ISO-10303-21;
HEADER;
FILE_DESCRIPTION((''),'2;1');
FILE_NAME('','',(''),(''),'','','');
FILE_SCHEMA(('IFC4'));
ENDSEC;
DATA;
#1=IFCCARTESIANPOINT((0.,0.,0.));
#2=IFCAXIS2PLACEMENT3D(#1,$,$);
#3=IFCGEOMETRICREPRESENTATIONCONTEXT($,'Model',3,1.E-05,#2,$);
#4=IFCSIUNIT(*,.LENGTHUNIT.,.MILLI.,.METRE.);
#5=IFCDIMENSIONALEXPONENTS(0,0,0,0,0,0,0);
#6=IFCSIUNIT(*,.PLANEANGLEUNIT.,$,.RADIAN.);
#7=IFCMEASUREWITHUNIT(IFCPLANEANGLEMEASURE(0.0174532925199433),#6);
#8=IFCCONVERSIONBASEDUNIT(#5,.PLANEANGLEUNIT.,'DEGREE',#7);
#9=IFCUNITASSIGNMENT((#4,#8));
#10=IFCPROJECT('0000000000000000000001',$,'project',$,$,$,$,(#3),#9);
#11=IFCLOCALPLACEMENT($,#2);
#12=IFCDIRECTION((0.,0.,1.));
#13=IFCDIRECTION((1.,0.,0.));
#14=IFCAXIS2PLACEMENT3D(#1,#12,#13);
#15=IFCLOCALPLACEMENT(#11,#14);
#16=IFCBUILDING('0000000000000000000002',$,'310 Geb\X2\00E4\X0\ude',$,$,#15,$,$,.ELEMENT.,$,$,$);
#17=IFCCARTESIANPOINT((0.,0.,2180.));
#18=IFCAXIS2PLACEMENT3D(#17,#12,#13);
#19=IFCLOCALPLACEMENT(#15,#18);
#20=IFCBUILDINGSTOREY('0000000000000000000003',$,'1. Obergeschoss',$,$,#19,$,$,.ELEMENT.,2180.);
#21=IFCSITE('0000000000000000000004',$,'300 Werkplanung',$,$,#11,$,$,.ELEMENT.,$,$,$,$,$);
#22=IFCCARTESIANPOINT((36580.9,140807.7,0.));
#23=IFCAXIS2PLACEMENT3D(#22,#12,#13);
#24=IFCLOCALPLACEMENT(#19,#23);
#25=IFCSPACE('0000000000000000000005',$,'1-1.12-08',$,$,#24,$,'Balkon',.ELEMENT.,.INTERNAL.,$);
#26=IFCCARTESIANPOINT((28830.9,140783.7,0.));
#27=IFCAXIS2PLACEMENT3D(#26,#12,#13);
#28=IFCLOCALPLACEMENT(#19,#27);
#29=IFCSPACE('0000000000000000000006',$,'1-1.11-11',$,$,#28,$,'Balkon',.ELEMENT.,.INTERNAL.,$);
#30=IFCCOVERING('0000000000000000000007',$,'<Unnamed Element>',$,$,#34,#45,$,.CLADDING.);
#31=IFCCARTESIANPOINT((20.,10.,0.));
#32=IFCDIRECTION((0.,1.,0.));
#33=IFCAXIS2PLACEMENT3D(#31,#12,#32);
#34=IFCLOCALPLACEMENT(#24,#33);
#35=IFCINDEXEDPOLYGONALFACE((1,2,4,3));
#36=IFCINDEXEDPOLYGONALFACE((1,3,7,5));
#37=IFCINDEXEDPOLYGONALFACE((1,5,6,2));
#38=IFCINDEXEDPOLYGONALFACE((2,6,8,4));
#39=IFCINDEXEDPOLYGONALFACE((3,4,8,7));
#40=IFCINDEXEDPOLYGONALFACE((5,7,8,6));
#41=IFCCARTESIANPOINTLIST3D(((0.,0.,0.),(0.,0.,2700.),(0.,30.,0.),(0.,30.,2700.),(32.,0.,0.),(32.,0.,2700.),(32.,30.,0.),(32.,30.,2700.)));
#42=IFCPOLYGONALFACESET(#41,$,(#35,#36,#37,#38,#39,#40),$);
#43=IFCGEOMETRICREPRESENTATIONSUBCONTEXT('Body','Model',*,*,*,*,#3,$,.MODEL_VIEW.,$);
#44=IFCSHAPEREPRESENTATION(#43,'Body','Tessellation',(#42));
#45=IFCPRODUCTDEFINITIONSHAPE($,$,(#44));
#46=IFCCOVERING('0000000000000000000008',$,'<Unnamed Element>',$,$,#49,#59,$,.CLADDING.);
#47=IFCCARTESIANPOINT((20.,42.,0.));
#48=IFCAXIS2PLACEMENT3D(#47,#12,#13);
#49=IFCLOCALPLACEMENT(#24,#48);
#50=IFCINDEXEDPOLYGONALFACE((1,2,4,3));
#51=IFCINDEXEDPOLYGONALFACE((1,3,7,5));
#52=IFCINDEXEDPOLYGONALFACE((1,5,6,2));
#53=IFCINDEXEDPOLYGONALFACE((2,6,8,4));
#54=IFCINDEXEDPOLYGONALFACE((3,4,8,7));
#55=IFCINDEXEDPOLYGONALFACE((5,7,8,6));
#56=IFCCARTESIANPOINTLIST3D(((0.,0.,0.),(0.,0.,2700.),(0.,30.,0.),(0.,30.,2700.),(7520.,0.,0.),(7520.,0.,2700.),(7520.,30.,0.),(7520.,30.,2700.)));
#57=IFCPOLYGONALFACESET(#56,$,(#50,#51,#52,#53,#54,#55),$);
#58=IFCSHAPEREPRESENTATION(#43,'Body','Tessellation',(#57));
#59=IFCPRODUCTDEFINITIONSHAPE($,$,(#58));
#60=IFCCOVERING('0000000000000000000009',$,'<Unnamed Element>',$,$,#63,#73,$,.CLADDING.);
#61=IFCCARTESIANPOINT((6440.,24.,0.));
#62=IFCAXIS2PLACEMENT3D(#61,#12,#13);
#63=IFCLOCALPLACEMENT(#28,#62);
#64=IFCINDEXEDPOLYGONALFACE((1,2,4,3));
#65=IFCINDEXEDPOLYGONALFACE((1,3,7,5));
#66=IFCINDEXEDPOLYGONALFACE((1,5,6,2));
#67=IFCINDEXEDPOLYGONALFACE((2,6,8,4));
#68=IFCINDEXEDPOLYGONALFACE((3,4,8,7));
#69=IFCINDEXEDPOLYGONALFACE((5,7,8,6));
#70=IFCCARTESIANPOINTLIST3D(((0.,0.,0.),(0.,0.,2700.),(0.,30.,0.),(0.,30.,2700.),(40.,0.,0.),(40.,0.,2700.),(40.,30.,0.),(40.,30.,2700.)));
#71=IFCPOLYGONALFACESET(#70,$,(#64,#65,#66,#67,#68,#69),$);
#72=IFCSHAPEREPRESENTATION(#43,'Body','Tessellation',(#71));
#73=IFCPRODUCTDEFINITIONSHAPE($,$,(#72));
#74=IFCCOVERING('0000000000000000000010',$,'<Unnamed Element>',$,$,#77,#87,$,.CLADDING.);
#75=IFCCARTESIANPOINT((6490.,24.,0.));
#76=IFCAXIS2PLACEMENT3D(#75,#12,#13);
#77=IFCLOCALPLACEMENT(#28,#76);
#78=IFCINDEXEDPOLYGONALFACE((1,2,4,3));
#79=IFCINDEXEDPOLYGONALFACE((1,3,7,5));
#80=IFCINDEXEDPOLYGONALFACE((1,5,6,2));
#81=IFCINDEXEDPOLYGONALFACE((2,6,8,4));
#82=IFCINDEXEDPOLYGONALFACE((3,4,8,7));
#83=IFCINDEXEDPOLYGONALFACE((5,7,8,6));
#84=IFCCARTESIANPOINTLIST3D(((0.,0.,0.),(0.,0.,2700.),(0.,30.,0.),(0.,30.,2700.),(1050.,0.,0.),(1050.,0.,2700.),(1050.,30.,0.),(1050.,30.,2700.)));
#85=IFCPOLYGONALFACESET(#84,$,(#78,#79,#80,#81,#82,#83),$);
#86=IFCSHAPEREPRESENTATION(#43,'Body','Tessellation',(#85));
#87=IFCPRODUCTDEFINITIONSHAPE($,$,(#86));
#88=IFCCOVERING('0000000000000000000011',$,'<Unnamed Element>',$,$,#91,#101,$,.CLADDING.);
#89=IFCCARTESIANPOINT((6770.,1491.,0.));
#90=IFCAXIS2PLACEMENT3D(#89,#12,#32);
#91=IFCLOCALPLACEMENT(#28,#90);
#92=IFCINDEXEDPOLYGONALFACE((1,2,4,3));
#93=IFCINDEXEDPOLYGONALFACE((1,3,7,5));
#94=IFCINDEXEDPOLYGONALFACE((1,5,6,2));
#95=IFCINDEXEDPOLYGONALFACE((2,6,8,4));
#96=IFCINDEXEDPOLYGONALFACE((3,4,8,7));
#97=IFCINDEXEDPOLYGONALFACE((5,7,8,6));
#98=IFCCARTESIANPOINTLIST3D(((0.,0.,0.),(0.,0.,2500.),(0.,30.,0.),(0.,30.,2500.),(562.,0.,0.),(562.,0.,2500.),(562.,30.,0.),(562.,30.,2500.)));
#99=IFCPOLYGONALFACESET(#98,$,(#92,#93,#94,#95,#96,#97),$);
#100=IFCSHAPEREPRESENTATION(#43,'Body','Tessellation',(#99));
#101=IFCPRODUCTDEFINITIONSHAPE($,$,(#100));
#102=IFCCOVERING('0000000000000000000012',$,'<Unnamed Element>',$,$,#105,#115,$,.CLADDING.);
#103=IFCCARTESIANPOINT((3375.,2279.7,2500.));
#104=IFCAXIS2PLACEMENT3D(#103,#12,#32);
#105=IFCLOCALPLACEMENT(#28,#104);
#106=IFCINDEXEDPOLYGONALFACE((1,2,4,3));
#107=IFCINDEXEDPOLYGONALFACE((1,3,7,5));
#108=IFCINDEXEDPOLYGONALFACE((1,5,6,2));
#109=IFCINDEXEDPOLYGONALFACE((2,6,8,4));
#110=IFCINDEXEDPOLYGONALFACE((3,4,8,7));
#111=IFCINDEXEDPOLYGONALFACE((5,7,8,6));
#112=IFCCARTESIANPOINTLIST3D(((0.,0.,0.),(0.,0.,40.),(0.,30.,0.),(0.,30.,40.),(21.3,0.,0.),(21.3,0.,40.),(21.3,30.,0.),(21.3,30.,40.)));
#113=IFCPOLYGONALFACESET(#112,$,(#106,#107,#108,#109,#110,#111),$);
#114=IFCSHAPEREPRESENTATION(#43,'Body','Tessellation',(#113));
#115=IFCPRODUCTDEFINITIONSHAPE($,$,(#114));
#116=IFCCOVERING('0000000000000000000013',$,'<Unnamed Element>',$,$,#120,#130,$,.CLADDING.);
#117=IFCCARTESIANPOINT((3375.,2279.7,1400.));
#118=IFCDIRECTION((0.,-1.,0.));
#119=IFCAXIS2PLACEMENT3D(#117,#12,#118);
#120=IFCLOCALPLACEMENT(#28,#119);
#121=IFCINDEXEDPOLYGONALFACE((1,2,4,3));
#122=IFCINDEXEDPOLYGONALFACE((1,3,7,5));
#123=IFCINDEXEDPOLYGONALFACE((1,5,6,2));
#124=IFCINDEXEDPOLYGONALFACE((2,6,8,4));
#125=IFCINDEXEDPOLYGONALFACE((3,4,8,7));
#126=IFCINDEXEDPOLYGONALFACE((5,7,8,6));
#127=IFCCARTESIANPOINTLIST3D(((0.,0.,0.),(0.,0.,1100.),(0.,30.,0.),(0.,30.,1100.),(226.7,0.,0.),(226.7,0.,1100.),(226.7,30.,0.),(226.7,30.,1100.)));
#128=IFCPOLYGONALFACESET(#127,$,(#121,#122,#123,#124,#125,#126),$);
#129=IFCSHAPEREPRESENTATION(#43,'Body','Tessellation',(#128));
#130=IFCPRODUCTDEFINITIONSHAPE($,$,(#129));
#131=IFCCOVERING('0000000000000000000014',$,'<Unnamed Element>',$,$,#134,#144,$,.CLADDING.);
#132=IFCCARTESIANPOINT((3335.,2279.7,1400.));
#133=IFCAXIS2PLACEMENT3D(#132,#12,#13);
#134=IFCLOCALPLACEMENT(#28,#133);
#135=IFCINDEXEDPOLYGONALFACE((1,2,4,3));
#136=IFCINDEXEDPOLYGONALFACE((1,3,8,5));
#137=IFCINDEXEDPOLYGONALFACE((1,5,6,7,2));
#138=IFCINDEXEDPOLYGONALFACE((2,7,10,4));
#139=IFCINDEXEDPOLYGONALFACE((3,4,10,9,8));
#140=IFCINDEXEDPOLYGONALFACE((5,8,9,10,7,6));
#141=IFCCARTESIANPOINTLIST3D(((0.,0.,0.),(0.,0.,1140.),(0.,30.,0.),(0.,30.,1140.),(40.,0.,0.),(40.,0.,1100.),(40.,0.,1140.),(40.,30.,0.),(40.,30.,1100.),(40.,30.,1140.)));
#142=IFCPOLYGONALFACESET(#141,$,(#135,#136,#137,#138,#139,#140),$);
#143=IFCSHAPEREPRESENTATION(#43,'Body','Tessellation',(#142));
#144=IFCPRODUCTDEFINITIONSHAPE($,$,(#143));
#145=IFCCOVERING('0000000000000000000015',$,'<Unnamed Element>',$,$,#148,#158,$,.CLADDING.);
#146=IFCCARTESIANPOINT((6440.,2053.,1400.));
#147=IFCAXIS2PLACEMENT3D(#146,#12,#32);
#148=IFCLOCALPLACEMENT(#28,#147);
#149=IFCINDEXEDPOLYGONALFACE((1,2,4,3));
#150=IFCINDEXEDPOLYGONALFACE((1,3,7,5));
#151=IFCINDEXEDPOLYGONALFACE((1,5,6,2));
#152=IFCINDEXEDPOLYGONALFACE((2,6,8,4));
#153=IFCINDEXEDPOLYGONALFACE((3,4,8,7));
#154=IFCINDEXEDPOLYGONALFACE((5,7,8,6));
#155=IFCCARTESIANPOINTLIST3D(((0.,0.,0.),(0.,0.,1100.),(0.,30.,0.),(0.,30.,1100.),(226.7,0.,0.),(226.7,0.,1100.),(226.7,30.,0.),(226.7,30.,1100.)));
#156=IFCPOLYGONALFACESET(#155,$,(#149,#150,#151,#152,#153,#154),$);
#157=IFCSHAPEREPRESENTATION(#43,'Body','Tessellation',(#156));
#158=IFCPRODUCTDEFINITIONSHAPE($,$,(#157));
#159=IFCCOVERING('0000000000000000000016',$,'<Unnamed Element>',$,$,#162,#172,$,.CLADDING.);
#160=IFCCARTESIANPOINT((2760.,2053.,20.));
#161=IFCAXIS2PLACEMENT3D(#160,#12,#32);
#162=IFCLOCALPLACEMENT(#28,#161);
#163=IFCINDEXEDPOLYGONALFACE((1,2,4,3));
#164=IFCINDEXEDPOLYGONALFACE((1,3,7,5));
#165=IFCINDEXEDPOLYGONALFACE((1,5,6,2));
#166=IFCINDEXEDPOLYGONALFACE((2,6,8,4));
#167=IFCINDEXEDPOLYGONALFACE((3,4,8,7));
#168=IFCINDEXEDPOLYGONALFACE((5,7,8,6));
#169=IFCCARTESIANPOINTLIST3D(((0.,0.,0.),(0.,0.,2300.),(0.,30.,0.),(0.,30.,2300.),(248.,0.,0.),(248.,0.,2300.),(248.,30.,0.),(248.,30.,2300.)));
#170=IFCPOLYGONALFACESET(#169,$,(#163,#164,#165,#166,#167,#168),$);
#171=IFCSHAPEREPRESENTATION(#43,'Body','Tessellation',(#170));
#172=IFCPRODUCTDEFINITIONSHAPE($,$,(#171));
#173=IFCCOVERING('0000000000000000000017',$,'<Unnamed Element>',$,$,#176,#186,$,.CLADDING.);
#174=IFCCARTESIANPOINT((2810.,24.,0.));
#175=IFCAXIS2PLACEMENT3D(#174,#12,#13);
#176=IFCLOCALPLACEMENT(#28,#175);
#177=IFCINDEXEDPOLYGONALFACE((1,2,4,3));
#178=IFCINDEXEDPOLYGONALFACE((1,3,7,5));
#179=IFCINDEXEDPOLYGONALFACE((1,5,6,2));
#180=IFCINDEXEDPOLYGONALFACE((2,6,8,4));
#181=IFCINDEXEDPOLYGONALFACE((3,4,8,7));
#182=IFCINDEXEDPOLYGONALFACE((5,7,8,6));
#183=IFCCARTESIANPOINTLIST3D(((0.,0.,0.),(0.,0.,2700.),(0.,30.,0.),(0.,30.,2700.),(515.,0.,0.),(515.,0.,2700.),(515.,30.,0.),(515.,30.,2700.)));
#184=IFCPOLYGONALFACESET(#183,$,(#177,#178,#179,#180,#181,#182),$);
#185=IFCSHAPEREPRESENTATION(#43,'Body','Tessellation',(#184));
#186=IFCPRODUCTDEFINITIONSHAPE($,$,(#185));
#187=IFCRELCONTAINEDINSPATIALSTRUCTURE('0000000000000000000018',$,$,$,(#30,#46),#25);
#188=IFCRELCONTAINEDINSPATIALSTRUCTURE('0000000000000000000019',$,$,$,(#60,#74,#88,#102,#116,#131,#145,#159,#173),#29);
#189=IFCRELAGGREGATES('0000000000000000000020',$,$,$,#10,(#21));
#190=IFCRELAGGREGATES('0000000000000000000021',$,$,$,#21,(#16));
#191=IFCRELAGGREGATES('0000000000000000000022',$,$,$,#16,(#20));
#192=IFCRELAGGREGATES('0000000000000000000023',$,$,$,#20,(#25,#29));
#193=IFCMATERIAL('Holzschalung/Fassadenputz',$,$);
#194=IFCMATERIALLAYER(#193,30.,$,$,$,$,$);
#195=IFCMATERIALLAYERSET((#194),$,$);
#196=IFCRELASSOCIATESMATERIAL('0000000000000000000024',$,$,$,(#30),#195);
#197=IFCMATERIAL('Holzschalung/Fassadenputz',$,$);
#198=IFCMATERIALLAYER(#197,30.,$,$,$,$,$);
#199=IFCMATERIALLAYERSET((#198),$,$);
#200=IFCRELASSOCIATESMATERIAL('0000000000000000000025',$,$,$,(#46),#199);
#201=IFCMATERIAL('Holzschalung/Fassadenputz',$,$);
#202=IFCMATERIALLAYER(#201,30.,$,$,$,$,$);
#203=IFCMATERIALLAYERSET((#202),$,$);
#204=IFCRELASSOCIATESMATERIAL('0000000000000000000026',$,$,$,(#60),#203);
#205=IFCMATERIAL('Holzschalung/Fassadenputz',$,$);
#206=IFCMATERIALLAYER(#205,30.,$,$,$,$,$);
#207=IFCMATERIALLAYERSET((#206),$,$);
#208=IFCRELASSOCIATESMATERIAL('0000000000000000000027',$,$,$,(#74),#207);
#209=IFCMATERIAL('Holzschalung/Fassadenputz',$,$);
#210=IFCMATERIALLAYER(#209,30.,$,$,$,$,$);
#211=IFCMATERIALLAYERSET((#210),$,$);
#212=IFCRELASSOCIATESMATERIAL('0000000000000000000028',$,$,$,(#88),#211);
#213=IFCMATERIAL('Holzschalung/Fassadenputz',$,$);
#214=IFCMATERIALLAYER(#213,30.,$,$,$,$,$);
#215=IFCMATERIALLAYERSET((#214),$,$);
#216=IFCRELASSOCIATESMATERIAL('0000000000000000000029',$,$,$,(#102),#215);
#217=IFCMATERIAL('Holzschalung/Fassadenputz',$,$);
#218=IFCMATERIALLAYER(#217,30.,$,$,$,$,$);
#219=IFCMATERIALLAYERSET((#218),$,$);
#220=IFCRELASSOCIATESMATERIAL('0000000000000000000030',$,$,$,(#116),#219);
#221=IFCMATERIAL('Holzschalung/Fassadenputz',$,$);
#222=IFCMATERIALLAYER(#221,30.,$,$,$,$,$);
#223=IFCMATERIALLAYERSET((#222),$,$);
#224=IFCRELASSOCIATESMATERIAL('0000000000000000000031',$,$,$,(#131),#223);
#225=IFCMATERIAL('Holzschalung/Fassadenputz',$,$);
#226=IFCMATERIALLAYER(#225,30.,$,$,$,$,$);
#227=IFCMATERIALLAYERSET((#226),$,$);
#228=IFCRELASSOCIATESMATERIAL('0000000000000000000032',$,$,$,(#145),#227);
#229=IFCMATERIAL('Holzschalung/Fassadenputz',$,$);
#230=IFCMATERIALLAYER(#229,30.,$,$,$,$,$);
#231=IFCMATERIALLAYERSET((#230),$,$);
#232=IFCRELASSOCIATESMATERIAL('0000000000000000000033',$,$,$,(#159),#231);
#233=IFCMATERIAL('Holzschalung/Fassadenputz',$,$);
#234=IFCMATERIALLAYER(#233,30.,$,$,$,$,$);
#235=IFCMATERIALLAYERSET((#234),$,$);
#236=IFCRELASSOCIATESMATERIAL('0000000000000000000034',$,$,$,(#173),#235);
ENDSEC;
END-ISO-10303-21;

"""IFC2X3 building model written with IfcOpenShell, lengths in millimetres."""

from ifc_helpers import new_model, entity, si_unit, converted_unit, frame, frame_2d, origin, origin_with_axes, place, context, subcontext, project, spatial, polyline, rectangle, outline, extrude, material, layer, layer_set, layer_usage, element, save


model = new_model("IFC2X3")

# Units and contexts
model_context = context("Model", 3, precision=1e-05, world=origin())
body_context = subcontext(model_context, "Body", "Model", "MODEL_VIEW")
ifc_project = project(units=[si_unit("LENGTHUNIT", "METRE", prefix="MILLI"), converted_unit("PLANEANGLEUNIT", "DEGREE", entity("IfcPlaneAngleMeasure", 0.0174532925199433), si_unit("PLANEANGLEUNIT", "RADIAN"), dimensions=[0, 0, 0, 0, 0, 0, 0])], contexts=[model_context])

# Site, building, storey
site_placement = place(None, origin())
site = spatial("IfcSite", under=ifc_project, at=site_placement, Name="300 Werkplanung", CompositionType="ELEMENT")
building_placement = place(site_placement, origin_with_axes())
building = spatial("IfcBuilding", under=site, at=building_placement, Name="310 Gebäude", CompositionType="ELEMENT")
storey_placement = place(building_placement, frame((0.0, 0.0, 2180.0), z_axis=(0.0, 0.0, 1.0), x_axis=(1.0, 0.0, 0.0)))
storey = spatial("IfcBuildingStorey", under=building, at=storey_placement, Name="1. Obergeschoss", CompositionType="ELEMENT", Elevation=2180.0)

# Shared definitions
space_1_placement = place(storey_placement, frame((36580.9, 140807.7, 0.0), z_axis=(0.0, 0.0, 1.0), x_axis=(1.0, 0.0, 0.0)))
space_1 = spatial("IfcSpace", under=storey, at=space_1_placement, Name="1-1.12-08", LongName="Balkon", CompositionType="ELEMENT", InteriorOrExteriorSpace="INTERNAL")

# Coverings
ifc_material_1 = material(Name="Holzschalung/Fassadenputz")
ifc_layer_1 = layer(ifc_material_1, 30.0)
ifc_layer_set_1 = layer_set([ifc_layer_1])
ifc_layer_usage_1 = layer_usage(ifc_layer_set_1, "AXIS3", "POSITIVE", 0.0)
covering_1_placement = place(space_1_placement, frame((20.0, 10.0, 0.0), z_axis=(0.0, 0.0, 1.0), x_axis=(0.0, 1.0, 0.0)))
element("IfcCovering", 1, at=covering_1_placement, inside=space_1, material=ifc_layer_usage_1, Name="<Unnamed Element>", PredefinedType="CLADDING", context=body_context, shape_type="SweptSolid", body=[
    extrude(rectangle(XDim=2700.0, YDim=32.0, at=frame_2d((-16.0, 1350.0), x_axis=(0.0, 1.0))), frame((32.0, 0.0, 2700.0), z_axis=(0.0, 1.0, 0.0), x_axis=(1.0, 0.0, 0.0)), (0.0, 0.0, 1.0), 30.0),
])
ifc_material_2 = material(Name="Holzschalung/Fassadenputz")
ifc_layer_2 = layer(ifc_material_2, 30.0)
ifc_layer_set_2 = layer_set([ifc_layer_2])
ifc_layer_usage_2 = layer_usage(ifc_layer_set_2, "AXIS3", "POSITIVE", 0.0)
covering_2_placement = place(space_1_placement, frame((20.0, 42.0, 0.0), z_axis=(0.0, 0.0, 1.0), x_axis=(1.0, 0.0, 0.0)))
element("IfcCovering", 2, at=covering_2_placement, inside=space_1, material=ifc_layer_usage_2, Name="<Unnamed Element>", PredefinedType="CLADDING", context=body_context, shape_type="SweptSolid", body=[
    extrude(rectangle(XDim=7520.0, YDim=2700.0, at=frame_2d((-3760.0, -1350.0), x_axis=(-1.0, 0.0))), frame((7520.0, 0.0, 0.0), z_axis=(0.0, 1.0, 0.0), x_axis=(1.0, 0.0, 0.0)), (0.0, 0.0, 1.0), 30.0),
])

# Shared definitions
space_2_placement = place(storey_placement, frame((28830.9, 140783.7, 0.0), z_axis=(0.0, 0.0, 1.0), x_axis=(1.0, 0.0, 0.0)))
space_2 = spatial("IfcSpace", under=storey, at=space_2_placement, Name="1-1.11-11", LongName="Balkon", CompositionType="ELEMENT", InteriorOrExteriorSpace="INTERNAL")

# Coverings
ifc_material_3 = material(Name="Holzschalung/Fassadenputz")
ifc_layer_3 = layer(ifc_material_3, 30.0)
ifc_layer_set_3 = layer_set([ifc_layer_3])
ifc_layer_usage_3 = layer_usage(ifc_layer_set_3, "AXIS3", "POSITIVE", 0.0)
covering_3_placement = place(space_2_placement, frame((6440.0, 24.0, 0.0), z_axis=(0.0, 0.0, 1.0), x_axis=(1.0, 0.0, 0.0)))
element("IfcCovering", 3, at=covering_3_placement, inside=space_2, material=ifc_layer_usage_3, Name="<Unnamed Element>", PredefinedType="CLADDING", context=body_context, shape_type="SweptSolid", body=[
    extrude(rectangle(XDim=2700.0, YDim=40.0, at=frame_2d((-20.0, 1350.0), x_axis=(0.0, 1.0))), frame((40.0, 0.0, 2700.0), z_axis=(0.0, 1.0, 0.0), x_axis=(1.0, 0.0, 0.0)), (0.0, 0.0, 1.0), 30.0),
])
ifc_material_4 = material(Name="Holzschalung/Fassadenputz")
ifc_layer_4 = layer(ifc_material_4, 30.0)
ifc_layer_set_4 = layer_set([ifc_layer_4])
ifc_layer_usage_4 = layer_usage(ifc_layer_set_4, "AXIS3", "POSITIVE", 0.0)
covering_4_placement = place(space_2_placement, frame((6490.0, 24.0, 0.0), z_axis=(0.0, 0.0, 1.0), x_axis=(1.0, 0.0, 0.0)))
element("IfcCovering", 4, at=covering_4_placement, inside=space_2, material=ifc_layer_usage_4, Name="<Unnamed Element>", PredefinedType="CLADDING", context=body_context, shape_type="SweptSolid", body=[
    extrude(rectangle(XDim=2700.0, YDim=1050.0, at=frame_2d((-525.0, 1350.0), x_axis=(0.0, 1.0))), frame((1050.0, 0.0, 2700.0), z_axis=(0.0, 1.0, 0.0), x_axis=(1.0, 0.0, 0.0)), (0.0, 0.0, 1.0), 30.0),
])
ifc_material_5 = material(Name="Holzschalung/Fassadenputz")
ifc_layer_5 = layer(ifc_material_5, 30.0)
ifc_layer_set_5 = layer_set([ifc_layer_5])
ifc_layer_usage_5 = layer_usage(ifc_layer_set_5, "AXIS3", "POSITIVE", 0.0)
covering_5_placement = place(space_2_placement, frame((6770.0, 1491.0, 0.0), z_axis=(0.0, 0.0, 1.0), x_axis=(0.0, 1.0, 0.0)))
element("IfcCovering", 5, at=covering_5_placement, inside=space_2, material=ifc_layer_usage_5, Name="<Unnamed Element>", PredefinedType="CLADDING", context=body_context, shape_type="SweptSolid", body=[
    extrude(rectangle(XDim=2500.0, YDim=562.0, at=frame_2d((-281.0, 1250.0), x_axis=(0.0, 1.0))), frame((562.0, 0.0, 2500.0), z_axis=(0.0, 1.0, 0.0), x_axis=(1.0, 0.0, 0.0)), (0.0, 0.0, 1.0), 30.0),
])
ifc_material_6 = material(Name="Holzschalung/Fassadenputz")
ifc_layer_6 = layer(ifc_material_6, 30.0)
ifc_layer_set_6 = layer_set([ifc_layer_6])
ifc_layer_usage_6 = layer_usage(ifc_layer_set_6, "AXIS3", "POSITIVE", 0.0)
covering_6_placement = place(space_2_placement, frame((3375.0, 2279.7, 2500.0), z_axis=(0.0, 0.0, 1.0), x_axis=(0.0, 1.0, 0.0)))
element("IfcCovering", 6, at=covering_6_placement, inside=space_2, material=ifc_layer_usage_6, Name="<Unnamed Element>", PredefinedType="CLADDING", context=body_context, shape_type="SweptSolid", body=[
    extrude(rectangle(XDim=21.3, YDim=40.0, at=frame_2d((-10.7, -20.0), x_axis=(-1.0, 0.0))), frame((21.3, 0.0, 0.0), z_axis=(0.0, 1.0, 0.0), x_axis=(1.0, 0.0, 0.0)), (0.0, 0.0, 1.0), 30.0),
])
ifc_material_7 = material(Name="Holzschalung/Fassadenputz")
ifc_layer_7 = layer(ifc_material_7, 30.0)
ifc_layer_set_7 = layer_set([ifc_layer_7])
ifc_layer_usage_7 = layer_usage(ifc_layer_set_7, "AXIS3", "POSITIVE", 0.0)
covering_7_placement = place(space_2_placement, frame((3375.0, 2279.7, 1400.0), z_axis=(0.0, 0.0, 1.0), x_axis=(0.0, -1.0, 0.0)))
element("IfcCovering", 7, at=covering_7_placement, inside=space_2, material=ifc_layer_usage_7, Name="<Unnamed Element>", PredefinedType="CLADDING", context=body_context, shape_type="SweptSolid", body=[
    extrude(rectangle(XDim=226.7, YDim=1100.0, at=frame_2d((-113.3, -550.0), x_axis=(-1.0, 0.0))), frame((226.7, 0.0, 0.0), z_axis=(0.0, 1.0, 0.0), x_axis=(1.0, 0.0, 0.0)), (0.0, 0.0, 1.0), 30.0),
])
ifc_material_8 = material(Name="Holzschalung/Fassadenputz")
ifc_layer_8 = layer(ifc_material_8, 30.0)
ifc_layer_set_8 = layer_set([ifc_layer_8])
ifc_layer_usage_8 = layer_usage(ifc_layer_set_8, "AXIS3", "POSITIVE", 0.0)
covering_8_placement = place(space_2_placement, frame((3335.0, 2279.7, 1400.0), z_axis=(0.0, 0.0, 1.0), x_axis=(1.0, 0.0, 0.0)))
element("IfcCovering", 8, at=covering_8_placement, inside=space_2, material=ifc_layer_usage_8, Name="<Unnamed Element>", PredefinedType="CLADDING", context=body_context, shape_type="SweptSolid", body=[
    extrude(outline(polyline([(0.0, 0.0), (40.0, 0.0), (40.0, -1100.0), (40.0, -1140.0), (0.0, -1140.0), (0.0, 0.0)])), frame((0.0, 0.0, 0.0), z_axis=(0.0, 1.0, 0.0), x_axis=(1.0, 0.0, 0.0)), (0.0, 0.0, 1.0), 30.0),
])
ifc_material_9 = material(Name="Holzschalung/Fassadenputz")
ifc_layer_9 = layer(ifc_material_9, 30.0)
ifc_layer_set_9 = layer_set([ifc_layer_9])
ifc_layer_usage_9 = layer_usage(ifc_layer_set_9, "AXIS3", "POSITIVE", 0.0)
covering_9_placement = place(space_2_placement, frame((6440.0, 2053.0, 1400.0), z_axis=(0.0, 0.0, 1.0), x_axis=(0.0, 1.0, 0.0)))
element("IfcCovering", 9, at=covering_9_placement, inside=space_2, material=ifc_layer_usage_9, Name="<Unnamed Element>", PredefinedType="CLADDING", context=body_context, shape_type="SweptSolid", body=[
    extrude(rectangle(XDim=226.7, YDim=1100.0, at=frame_2d((-113.4, -550.0), x_axis=(-1.0, 0.0))), frame((226.7, 0.0, 0.0), z_axis=(0.0, 1.0, 0.0), x_axis=(1.0, 0.0, 0.0)), (0.0, 0.0, 1.0), 30.0),
])
ifc_material_10 = material(Name="Holzschalung/Fassadenputz")
ifc_layer_10 = layer(ifc_material_10, 30.0)
ifc_layer_set_10 = layer_set([ifc_layer_10])
ifc_layer_usage_10 = layer_usage(ifc_layer_set_10, "AXIS3", "POSITIVE", 0.0)
covering_10_placement = place(space_2_placement, frame((2760.0, 2053.0, 20.0), z_axis=(0.0, 0.0, 1.0), x_axis=(0.0, 1.0, 0.0)))
element("IfcCovering", 10, at=covering_10_placement, inside=space_2, material=ifc_layer_usage_10, Name="<Unnamed Element>", PredefinedType="CLADDING", context=body_context, shape_type="SweptSolid", body=[
    extrude(rectangle(XDim=248.0, YDim=2300.0, at=frame_2d((-124.0, -1150.0), x_axis=(-1.0, 0.0))), frame((248.0, 0.0, 0.0), z_axis=(0.0, 1.0, 0.0), x_axis=(1.0, 0.0, 0.0)), (0.0, 0.0, 1.0), 30.0),
])
ifc_material_11 = material(Name="Holzschalung/Fassadenputz")
ifc_layer_11 = layer(ifc_material_11, 30.0)
ifc_layer_set_11 = layer_set([ifc_layer_11])
ifc_layer_usage_11 = layer_usage(ifc_layer_set_11, "AXIS3", "POSITIVE", 0.0)
covering_11_placement = place(space_2_placement, frame((2810.0, 24.0, 0.0), z_axis=(0.0, 0.0, 1.0), x_axis=(1.0, 0.0, 0.0)))
element("IfcCovering", 11, at=covering_11_placement, inside=space_2, material=ifc_layer_usage_11, Name="<Unnamed Element>", PredefinedType="CLADDING", context=body_context, shape_type="SweptSolid", body=[
    extrude(rectangle(XDim=2700.0, YDim=515.0, at=frame_2d((-257.5, 1350.0), x_axis=(0.0, 1.0))), frame((515.0, 0.0, 2700.0), z_axis=(0.0, 1.0, 0.0), x_axis=(1.0, 0.0, 0.0)), (0.0, 0.0, 1.0), 30.0),
])

save(model, "model.ifc")
